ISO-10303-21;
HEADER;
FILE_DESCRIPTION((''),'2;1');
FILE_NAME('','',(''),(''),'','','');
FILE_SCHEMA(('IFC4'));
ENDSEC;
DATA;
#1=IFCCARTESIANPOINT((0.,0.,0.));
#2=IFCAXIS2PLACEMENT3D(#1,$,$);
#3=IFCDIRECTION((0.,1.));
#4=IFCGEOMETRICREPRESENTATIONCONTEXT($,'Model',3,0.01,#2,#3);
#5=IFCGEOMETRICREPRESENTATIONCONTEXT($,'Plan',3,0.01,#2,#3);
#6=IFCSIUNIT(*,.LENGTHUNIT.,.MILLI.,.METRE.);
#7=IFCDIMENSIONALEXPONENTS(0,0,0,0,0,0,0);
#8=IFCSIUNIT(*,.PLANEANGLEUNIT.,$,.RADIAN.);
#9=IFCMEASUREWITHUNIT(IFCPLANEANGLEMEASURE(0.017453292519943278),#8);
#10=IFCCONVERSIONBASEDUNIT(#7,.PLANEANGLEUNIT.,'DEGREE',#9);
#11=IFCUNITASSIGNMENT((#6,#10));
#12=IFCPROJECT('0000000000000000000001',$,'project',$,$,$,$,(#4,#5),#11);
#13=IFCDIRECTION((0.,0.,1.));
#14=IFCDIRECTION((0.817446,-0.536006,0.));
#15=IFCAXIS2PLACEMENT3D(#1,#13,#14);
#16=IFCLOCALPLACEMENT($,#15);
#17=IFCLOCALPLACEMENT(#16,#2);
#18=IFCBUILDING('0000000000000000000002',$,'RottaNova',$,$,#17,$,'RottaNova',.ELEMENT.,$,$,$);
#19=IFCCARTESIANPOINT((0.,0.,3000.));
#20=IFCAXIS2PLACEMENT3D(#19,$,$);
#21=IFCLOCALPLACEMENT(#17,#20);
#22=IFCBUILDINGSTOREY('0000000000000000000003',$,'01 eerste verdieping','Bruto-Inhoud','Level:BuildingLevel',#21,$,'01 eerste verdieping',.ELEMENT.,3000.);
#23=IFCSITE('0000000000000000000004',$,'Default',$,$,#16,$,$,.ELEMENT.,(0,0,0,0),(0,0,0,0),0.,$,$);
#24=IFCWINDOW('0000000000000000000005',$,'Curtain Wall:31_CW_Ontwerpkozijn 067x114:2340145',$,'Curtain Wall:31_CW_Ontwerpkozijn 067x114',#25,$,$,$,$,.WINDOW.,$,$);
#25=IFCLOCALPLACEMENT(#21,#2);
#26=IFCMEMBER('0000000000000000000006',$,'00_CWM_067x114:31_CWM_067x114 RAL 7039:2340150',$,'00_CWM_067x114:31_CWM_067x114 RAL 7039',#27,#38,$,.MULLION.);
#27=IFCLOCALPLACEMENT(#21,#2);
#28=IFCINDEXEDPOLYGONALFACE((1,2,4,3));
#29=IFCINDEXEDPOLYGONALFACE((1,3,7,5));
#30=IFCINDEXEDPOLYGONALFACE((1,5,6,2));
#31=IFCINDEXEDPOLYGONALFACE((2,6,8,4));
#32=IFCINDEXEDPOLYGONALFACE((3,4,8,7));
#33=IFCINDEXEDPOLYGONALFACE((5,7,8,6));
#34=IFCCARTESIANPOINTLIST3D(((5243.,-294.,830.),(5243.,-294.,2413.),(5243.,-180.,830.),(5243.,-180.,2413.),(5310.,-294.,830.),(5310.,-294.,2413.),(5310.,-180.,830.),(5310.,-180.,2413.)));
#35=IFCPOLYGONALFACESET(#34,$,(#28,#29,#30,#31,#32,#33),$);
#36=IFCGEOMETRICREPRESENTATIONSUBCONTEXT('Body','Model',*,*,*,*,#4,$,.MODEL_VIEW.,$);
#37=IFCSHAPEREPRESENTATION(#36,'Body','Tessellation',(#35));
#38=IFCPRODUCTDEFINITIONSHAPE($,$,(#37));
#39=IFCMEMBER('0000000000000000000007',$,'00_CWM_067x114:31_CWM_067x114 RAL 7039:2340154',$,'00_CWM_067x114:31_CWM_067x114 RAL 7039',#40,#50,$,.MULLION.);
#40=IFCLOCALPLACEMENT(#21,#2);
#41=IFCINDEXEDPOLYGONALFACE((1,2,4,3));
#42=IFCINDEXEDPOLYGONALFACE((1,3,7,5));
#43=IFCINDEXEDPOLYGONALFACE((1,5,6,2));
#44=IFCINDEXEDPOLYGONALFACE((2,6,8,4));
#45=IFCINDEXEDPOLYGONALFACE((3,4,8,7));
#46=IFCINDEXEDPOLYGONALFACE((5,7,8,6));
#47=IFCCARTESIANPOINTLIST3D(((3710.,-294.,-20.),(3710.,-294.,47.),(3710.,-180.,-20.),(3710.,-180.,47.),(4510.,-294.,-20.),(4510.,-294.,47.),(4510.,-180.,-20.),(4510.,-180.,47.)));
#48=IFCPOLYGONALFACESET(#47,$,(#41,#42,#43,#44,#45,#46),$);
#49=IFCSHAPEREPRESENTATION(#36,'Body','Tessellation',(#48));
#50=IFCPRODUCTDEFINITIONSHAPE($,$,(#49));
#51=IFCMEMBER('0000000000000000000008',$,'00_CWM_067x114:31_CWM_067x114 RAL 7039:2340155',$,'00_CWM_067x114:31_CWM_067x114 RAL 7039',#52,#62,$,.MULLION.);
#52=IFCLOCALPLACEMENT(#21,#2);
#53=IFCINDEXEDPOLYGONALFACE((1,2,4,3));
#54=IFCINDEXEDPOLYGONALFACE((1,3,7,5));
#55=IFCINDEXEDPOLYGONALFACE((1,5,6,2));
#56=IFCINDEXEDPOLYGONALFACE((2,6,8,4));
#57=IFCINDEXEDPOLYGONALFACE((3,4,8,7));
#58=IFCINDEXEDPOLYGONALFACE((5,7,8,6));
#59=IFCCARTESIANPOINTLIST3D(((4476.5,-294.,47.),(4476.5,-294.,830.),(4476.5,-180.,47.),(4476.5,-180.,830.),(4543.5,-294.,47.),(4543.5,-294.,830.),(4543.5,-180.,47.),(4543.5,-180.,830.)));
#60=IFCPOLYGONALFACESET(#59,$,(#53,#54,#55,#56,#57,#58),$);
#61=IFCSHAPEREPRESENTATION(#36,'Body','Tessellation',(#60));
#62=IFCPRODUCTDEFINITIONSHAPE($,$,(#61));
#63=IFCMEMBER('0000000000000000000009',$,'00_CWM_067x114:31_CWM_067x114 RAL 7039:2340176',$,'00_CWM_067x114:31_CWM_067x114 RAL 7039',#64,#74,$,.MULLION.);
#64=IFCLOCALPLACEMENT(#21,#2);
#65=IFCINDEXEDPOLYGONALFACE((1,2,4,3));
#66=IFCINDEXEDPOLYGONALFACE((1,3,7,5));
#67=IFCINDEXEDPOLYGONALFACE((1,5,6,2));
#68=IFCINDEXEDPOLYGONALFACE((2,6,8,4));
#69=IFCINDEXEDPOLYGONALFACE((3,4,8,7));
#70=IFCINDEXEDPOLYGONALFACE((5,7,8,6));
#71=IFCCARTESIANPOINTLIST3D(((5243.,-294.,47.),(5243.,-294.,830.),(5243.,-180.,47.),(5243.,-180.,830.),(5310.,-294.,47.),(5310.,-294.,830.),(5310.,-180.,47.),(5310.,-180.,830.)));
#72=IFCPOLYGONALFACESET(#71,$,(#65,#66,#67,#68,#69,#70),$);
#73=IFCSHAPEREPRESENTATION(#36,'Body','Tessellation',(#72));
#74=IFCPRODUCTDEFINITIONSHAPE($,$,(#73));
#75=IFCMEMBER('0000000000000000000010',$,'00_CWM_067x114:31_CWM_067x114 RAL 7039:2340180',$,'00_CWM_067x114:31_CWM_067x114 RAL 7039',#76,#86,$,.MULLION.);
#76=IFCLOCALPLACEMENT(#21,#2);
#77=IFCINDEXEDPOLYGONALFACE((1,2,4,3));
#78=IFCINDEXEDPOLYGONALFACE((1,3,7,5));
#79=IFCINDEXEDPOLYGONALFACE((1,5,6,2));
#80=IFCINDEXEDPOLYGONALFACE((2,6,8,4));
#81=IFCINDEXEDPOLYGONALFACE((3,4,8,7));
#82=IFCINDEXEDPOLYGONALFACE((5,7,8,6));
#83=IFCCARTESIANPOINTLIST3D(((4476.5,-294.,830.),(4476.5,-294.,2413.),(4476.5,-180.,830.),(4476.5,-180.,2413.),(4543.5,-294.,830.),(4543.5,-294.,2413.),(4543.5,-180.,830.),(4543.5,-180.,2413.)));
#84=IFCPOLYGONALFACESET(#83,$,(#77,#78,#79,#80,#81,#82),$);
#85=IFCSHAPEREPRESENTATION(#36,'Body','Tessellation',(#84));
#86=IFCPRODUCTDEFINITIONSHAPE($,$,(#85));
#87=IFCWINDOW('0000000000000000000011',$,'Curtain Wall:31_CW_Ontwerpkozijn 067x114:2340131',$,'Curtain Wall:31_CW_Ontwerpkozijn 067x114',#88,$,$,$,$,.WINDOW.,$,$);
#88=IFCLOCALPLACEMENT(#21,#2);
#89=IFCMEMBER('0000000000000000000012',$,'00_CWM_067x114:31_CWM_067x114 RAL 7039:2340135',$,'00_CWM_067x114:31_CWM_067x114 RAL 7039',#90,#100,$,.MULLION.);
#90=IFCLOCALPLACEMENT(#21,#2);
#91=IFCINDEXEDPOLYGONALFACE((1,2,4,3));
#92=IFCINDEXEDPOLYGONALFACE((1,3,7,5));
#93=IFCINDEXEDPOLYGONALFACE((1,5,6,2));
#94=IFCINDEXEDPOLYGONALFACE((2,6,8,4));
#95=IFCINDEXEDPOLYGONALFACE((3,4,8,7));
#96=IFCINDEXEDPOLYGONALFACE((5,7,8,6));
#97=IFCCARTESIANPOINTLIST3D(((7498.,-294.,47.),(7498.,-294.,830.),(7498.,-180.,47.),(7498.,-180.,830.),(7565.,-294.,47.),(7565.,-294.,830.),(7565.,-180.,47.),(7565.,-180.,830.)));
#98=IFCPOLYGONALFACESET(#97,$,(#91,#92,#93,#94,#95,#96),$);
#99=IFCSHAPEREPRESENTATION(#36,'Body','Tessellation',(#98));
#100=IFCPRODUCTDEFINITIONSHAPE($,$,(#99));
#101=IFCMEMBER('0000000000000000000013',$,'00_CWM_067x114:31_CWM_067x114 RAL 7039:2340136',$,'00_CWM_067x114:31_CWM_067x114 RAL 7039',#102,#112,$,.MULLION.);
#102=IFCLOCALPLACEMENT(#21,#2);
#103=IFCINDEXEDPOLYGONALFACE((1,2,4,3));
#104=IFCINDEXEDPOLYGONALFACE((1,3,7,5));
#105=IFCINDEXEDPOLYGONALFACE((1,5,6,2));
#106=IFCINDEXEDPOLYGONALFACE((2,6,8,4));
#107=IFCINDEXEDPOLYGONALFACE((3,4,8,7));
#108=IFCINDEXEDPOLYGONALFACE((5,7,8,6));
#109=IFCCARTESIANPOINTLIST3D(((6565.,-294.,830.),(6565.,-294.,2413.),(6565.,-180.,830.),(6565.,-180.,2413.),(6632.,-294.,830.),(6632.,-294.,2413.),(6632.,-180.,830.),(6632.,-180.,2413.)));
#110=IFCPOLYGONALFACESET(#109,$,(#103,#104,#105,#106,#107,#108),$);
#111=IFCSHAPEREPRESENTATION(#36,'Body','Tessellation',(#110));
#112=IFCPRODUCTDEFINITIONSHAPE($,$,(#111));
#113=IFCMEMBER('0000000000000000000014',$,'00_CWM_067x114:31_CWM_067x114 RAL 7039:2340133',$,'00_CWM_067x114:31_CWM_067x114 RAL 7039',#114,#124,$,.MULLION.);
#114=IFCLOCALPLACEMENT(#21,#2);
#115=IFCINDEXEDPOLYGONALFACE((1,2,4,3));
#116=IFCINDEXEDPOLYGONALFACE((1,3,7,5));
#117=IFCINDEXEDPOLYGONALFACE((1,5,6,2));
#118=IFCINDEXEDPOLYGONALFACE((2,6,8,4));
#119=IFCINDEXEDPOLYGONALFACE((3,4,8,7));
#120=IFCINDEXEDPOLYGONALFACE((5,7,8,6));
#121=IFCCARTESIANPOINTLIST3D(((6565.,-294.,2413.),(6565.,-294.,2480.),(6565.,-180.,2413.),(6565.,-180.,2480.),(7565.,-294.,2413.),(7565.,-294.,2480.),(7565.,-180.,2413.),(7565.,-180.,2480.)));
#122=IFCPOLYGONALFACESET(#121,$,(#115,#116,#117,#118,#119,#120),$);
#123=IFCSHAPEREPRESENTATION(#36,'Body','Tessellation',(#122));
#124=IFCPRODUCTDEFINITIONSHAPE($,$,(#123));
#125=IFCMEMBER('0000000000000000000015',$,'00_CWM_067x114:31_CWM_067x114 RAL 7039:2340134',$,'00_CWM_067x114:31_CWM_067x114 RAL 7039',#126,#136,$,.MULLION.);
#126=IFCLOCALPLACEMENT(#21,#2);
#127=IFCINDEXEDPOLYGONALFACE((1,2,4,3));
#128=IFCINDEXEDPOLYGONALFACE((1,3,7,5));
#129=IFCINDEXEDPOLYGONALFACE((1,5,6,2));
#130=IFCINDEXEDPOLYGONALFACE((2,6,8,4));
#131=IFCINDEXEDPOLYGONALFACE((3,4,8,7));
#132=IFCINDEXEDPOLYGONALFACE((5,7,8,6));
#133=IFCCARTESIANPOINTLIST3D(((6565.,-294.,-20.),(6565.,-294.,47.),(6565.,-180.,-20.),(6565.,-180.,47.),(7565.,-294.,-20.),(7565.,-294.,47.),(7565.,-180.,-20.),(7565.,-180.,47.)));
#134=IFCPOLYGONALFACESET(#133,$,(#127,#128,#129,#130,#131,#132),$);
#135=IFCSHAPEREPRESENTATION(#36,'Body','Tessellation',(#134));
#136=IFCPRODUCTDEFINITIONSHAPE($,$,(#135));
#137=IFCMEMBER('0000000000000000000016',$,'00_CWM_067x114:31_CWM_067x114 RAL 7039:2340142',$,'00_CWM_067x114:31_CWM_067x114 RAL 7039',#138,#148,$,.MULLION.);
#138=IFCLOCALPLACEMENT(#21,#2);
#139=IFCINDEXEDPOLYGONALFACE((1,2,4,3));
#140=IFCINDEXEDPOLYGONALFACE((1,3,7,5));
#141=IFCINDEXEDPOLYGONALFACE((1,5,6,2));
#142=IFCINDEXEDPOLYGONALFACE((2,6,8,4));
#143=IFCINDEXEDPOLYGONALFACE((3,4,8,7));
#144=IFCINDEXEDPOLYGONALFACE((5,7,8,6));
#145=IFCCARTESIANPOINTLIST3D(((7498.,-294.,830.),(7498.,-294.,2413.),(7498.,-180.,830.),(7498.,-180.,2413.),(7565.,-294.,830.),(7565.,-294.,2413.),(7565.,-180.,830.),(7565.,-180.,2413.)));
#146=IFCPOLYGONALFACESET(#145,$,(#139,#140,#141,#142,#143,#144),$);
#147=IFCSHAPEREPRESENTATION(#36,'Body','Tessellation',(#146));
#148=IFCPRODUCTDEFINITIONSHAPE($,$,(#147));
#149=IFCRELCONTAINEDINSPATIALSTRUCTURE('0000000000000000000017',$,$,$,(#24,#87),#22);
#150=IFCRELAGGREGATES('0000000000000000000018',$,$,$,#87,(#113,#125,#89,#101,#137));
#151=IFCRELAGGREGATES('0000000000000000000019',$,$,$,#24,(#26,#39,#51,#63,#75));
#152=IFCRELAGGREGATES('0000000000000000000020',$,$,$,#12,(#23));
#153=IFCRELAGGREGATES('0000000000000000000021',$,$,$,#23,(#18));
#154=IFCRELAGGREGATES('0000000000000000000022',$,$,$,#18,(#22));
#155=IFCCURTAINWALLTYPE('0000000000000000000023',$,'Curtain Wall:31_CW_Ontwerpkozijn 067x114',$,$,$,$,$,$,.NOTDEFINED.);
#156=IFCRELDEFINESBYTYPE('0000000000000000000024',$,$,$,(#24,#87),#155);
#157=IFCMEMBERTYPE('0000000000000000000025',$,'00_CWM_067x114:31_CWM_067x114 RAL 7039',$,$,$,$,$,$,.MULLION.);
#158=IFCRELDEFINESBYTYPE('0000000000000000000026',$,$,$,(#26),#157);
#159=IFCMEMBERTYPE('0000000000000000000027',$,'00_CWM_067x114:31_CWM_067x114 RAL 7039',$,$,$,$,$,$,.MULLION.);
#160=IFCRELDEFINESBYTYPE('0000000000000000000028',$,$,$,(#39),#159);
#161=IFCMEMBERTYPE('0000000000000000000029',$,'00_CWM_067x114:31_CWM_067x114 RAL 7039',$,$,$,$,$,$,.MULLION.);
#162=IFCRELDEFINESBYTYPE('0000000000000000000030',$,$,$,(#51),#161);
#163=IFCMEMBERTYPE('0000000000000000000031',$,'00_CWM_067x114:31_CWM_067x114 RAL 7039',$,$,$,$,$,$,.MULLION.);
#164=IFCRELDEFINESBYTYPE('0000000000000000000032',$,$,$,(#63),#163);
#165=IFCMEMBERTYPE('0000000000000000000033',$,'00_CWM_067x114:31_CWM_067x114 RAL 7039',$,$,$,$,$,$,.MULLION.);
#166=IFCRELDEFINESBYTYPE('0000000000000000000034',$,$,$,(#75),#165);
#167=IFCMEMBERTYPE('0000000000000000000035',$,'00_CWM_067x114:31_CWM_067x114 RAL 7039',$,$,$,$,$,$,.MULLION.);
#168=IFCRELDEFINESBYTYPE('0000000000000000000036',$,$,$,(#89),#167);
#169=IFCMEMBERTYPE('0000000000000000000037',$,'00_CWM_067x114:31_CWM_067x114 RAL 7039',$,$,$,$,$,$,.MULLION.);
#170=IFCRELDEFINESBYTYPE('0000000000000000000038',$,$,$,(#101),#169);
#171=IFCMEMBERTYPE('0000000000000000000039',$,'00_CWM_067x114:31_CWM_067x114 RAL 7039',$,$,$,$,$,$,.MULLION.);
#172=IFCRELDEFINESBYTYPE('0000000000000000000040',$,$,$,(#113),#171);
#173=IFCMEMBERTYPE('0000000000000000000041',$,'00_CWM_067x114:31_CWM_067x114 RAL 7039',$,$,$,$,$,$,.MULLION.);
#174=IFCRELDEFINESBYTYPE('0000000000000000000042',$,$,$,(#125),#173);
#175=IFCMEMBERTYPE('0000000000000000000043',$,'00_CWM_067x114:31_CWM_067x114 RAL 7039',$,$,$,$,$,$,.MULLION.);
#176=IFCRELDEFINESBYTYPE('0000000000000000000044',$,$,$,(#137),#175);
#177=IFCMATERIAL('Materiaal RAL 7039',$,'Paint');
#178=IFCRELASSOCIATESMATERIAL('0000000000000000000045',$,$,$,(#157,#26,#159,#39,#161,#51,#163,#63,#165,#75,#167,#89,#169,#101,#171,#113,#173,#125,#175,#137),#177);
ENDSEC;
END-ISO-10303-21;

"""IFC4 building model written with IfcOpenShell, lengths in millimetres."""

from ifc_helpers import new_model, entity, si_unit, converted_unit, direction, frame, origin, place, context, subcontext, project, spatial, indexed_curve, outline, extrude, source, transform, mapped, material, type_object, type_shapes, element, aggregate, save


model = new_model("IFC4")

# Units and contexts
model_context = context("Model", 3, precision=0.01, world=origin(), true_north=direction((0.0, 1.0)))
plan_context = context("Plan", 3, precision=0.01, world=origin(), true_north=direction((0.0, 1.0)))
body_context = subcontext(model_context, "Body", "Model", "MODEL_VIEW")
ifc_project = project(units=[si_unit("LENGTHUNIT", "METRE", prefix="MILLI"), converted_unit("PLANEANGLEUNIT", "DEGREE", entity("IfcPlaneAngleMeasure", 0.017453292519943278), si_unit("PLANEANGLEUNIT", "RADIAN"), dimensions=[0, 0, 0, 0, 0, 0, 0])], contexts=[model_context, plan_context])

# Site, building, storey
site_placement = place(None, frame((0.0, 0.0, 0.0), z_axis=(0.0, 0.0, 1.0), x_axis=(0.817446, -0.536006, 0.0)))
site = spatial("IfcSite", under=ifc_project, at=site_placement, Name="Default", CompositionType="ELEMENT", RefLatitude=(0, 0, 0, 0), RefLongitude=(0, 0, 0, 0), RefElevation=0.0)
building_placement = place(site_placement, origin())
building = spatial("IfcBuilding", under=site, at=building_placement, Name="RottaNova", LongName="RottaNova", CompositionType="ELEMENT")
storey_placement = place(building_placement, frame((0.0, 0.0, 3000.0)))
storey = spatial("IfcBuildingStorey", under=building, at=storey_placement, Name="01 eerste verdieping", Description="Bruto-Inhoud", ObjectType="Level:BuildingLevel", LongName="01 eerste verdieping", CompositionType="ELEMENT", Elevation=3000.0)

# Windows, members
curtain_wall_type = type_object("IfcCurtainWallType", Name="Curtain Wall:31_CW_Ontwerpkozijn 067x114", PredefinedType="NOTDEFINED")
window_1_placement = place(storey_placement, frame((0.0, 0.0, -3000.0)))
window_1 = element("IfcWindow", 1, at=window_1_placement, inside=storey, type_object=curtain_wall_type, Name="Curtain Wall:31_CW_Ontwerpkozijn 067x114:2340145", ObjectType="Curtain Wall:31_CW_Ontwerpkozijn 067x114", PredefinedType="WINDOW")
ifc_material_1 = material(Name="Materiaal RAL 7039", Category="Paint")
member_type_1 = type_object("IfcMemberType", Name="00_CWM_067x114:31_CWM_067x114 RAL 7039", PredefinedType="MULLION", material=ifc_material_1)
shared_shape_1 = source(origin(), body_context, "Body", "SweptSolid", [
    extrude(outline(indexed_curve([(-33.5, -57.0), (33.5, -57.0), (33.5, 57.0), (-33.5, 57.0), (-33.5, -57.0)], self_intersect=False)), frame((-33.5, -57.0, -1583.0), z_axis=(0.0, 0.0, 1.0), x_axis=(-1.0, 0.0, 0.0)), (0.0, 0.0, 1.0), 1583.0),
])
type_shapes(member_type_1, [shared_shape_1])
member_1_placement = place(window_1_placement, frame((5310.0, -180.0, 5413.0)))
member_1 = element("IfcMember", 2, at=member_1_placement, type_object=member_type_1, material=ifc_material_1, Name="00_CWM_067x114:31_CWM_067x114 RAL 7039:2340150", ObjectType="00_CWM_067x114:31_CWM_067x114 RAL 7039", PredefinedType="MULLION", context=body_context, shape_type="MappedRepresentation", body=[
    mapped(shared_shape_1, transform((0.0, 0.0, 0.0), scale=1.0)),
])
member_type_2 = type_object("IfcMemberType", Name="00_CWM_067x114:31_CWM_067x114 RAL 7039", PredefinedType="MULLION", material=ifc_material_1)
shared_shape_2 = source(origin(), body_context, "Body", "SweptSolid", [
    extrude(outline(indexed_curve([(-33.5, -57.0), (33.5, -57.0), (33.5, 57.0), (-33.5, 57.0), (-33.5, -57.0)], self_intersect=False)), frame((-33.5, -57.0, -800.0), z_axis=(0.0, 0.0, 1.0), x_axis=(-1.0, 0.0, 0.0)), (0.0, 0.0, 1.0), 800.0),
])
type_shapes(member_type_2, [shared_shape_2])
member_2_placement = place(window_1_placement, frame((4510.0, -180.0, 2980.0), z_axis=(1.0, 0.0, 0.0), x_axis=(0.0, 0.0, -1.0)))
member_2 = element("IfcMember", 3, at=member_2_placement, type_object=member_type_2, material=ifc_material_1, Name="00_CWM_067x114:31_CWM_067x114 RAL 7039:2340154", ObjectType="00_CWM_067x114:31_CWM_067x114 RAL 7039", PredefinedType="MULLION", context=body_context, shape_type="MappedRepresentation", body=[
    mapped(shared_shape_2, transform((0.0, 0.0, 0.0), scale=1.0)),
])
member_type_3 = type_object("IfcMemberType", Name="00_CWM_067x114:31_CWM_067x114 RAL 7039", PredefinedType="MULLION", material=ifc_material_1)
shared_shape_3 = source(origin(), body_context, "Body", "SweptSolid", [
    extrude(outline(indexed_curve([(-33.5, -57.0), (33.5, -57.0), (33.5, 57.0), (-33.5, 57.0), (-33.5, -57.0)], self_intersect=False)), frame((0.0, -57.0, -783.0), z_axis=(0.0, 0.0, 1.0), x_axis=(-1.0, 0.0, 0.0)), (0.0, 0.0, 1.0), 783.0),
])
type_shapes(member_type_3, [shared_shape_3])
member_3_placement = place(window_1_placement, frame((4510.0, -180.0, 3047.0), z_axis=(0.0, 0.0, -1.0), x_axis=(-1.0, 0.0, 0.0)))
member_3 = element("IfcMember", 4, at=member_3_placement, type_object=member_type_3, material=ifc_material_1, Name="00_CWM_067x114:31_CWM_067x114 RAL 7039:2340155", ObjectType="00_CWM_067x114:31_CWM_067x114 RAL 7039", PredefinedType="MULLION", context=body_context, shape_type="MappedRepresentation", body=[
    mapped(shared_shape_3, transform((0.0, 0.0, 0.0), scale=1.0)),
])
member_type_4 = type_object("IfcMemberType", Name="00_CWM_067x114:31_CWM_067x114 RAL 7039", PredefinedType="MULLION", material=ifc_material_1)
shared_shape_4 = source(origin(), body_context, "Body", "SweptSolid", [
    extrude(outline(indexed_curve([(-33.5, -57.0), (33.5, -57.0), (33.5, 57.0), (-33.5, 57.0), (-33.5, -57.0)], self_intersect=False)), frame((-33.5, -57.0, -783.0), z_axis=(0.0, 0.0, 1.0), x_axis=(-1.0, 0.0, 0.0)), (0.0, 0.0, 1.0), 783.0),
])
type_shapes(member_type_4, [shared_shape_4])
member_4_placement = place(window_1_placement, frame((5310.0, -180.0, 3830.0)))
member_4 = element("IfcMember", 5, at=member_4_placement, type_object=member_type_4, material=ifc_material_1, Name="00_CWM_067x114:31_CWM_067x114 RAL 7039:2340176", ObjectType="00_CWM_067x114:31_CWM_067x114 RAL 7039", PredefinedType="MULLION", context=body_context, shape_type="MappedRepresentation", body=[
    mapped(shared_shape_4, transform((0.0, 0.0, 0.0), scale=1.0)),
])
member_type_5 = type_object("IfcMemberType", Name="00_CWM_067x114:31_CWM_067x114 RAL 7039", PredefinedType="MULLION", material=ifc_material_1)
shared_shape_5 = source(origin(), body_context, "Body", "SweptSolid", [
    extrude(outline(indexed_curve([(-33.5, -57.0), (33.5, -57.0), (33.5, 57.0), (-33.5, 57.0), (-33.5, -57.0)], self_intersect=False)), frame((0.0, -57.0, -1583.0), z_axis=(0.0, 0.0, 1.0), x_axis=(-1.0, 0.0, 0.0)), (0.0, 0.0, 1.0), 1583.0),
])
type_shapes(member_type_5, [shared_shape_5])
member_5_placement = place(window_1_placement, frame((4510.0, -180.0, 3830.0), z_axis=(0.0, 0.0, -1.0), x_axis=(-1.0, 0.0, 0.0)))
member_5 = element("IfcMember", 6, at=member_5_placement, type_object=member_type_5, material=ifc_material_1, Name="00_CWM_067x114:31_CWM_067x114 RAL 7039:2340180", ObjectType="00_CWM_067x114:31_CWM_067x114 RAL 7039", PredefinedType="MULLION", context=body_context, shape_type="MappedRepresentation", body=[
    mapped(shared_shape_5, transform((0.0, 0.0, 0.0), scale=1.0)),
])
window_2_placement = place(storey_placement, frame((0.0, 0.0, -3000.0)))
window_2 = element("IfcWindow", 7, at=window_2_placement, inside=storey, type_object=curtain_wall_type, Name="Curtain Wall:31_CW_Ontwerpkozijn 067x114:2340131", ObjectType="Curtain Wall:31_CW_Ontwerpkozijn 067x114", PredefinedType="WINDOW")
member_type_6 = type_object("IfcMemberType", Name="00_CWM_067x114:31_CWM_067x114 RAL 7039", PredefinedType="MULLION", material=ifc_material_1)
shared_shape_6 = source(origin(), body_context, "Body", "SweptSolid", [
    extrude(outline(indexed_curve([(-33.5, -57.0), (33.5, -57.0), (33.5, 57.0), (-33.5, 57.0), (-33.5, -57.0)], self_intersect=False)), frame((-33.5, 57.0, -783.0), z_axis=(0.0, 0.0, 1.0), x_axis=(-1.0, 0.0, 0.0)), (0.0, 0.0, 1.0), 783.0),
])
type_shapes(member_type_6, [shared_shape_6])
member_6_placement = place(window_2_placement, frame((7565.0, -180.0, 3047.0), z_axis=(0.0, 0.0, -1.0), x_axis=(1.0, 0.0, 0.0)))
member_6 = element("IfcMember", 8, at=member_6_placement, type_object=member_type_6, material=ifc_material_1, Name="00_CWM_067x114:31_CWM_067x114 RAL 7039:2340135", ObjectType="00_CWM_067x114:31_CWM_067x114 RAL 7039", PredefinedType="MULLION", context=body_context, shape_type="MappedRepresentation", body=[
    mapped(shared_shape_6, transform((0.0, 0.0, 0.0), scale=1.0)),
])
member_type_7 = type_object("IfcMemberType", Name="00_CWM_067x114:31_CWM_067x114 RAL 7039", PredefinedType="MULLION", material=ifc_material_1)
shared_shape_7 = source(origin(), body_context, "Body", "SweptSolid", [
    extrude(outline(indexed_curve([(-33.5, -57.0), (33.5, -57.0), (33.5, 57.0), (-33.5, 57.0), (-33.5, -57.0)], self_intersect=False)), frame((-33.5, 57.0, -1583.0), z_axis=(0.0, 0.0, 1.0), x_axis=(-1.0, 0.0, 0.0)), (0.0, 0.0, 1.0), 1583.0),
])
type_shapes(member_type_7, [shared_shape_7])
member_7_placement = place(window_2_placement, frame((6565.0, -180.0, 5413.0), z_axis=(0.0, 0.0, 1.0), x_axis=(-1.0, 0.0, 0.0)))
member_7 = element("IfcMember", 9, at=member_7_placement, type_object=member_type_7, material=ifc_material_1, Name="00_CWM_067x114:31_CWM_067x114 RAL 7039:2340136", ObjectType="00_CWM_067x114:31_CWM_067x114 RAL 7039", PredefinedType="MULLION", context=body_context, shape_type="MappedRepresentation", body=[
    mapped(shared_shape_7, transform((0.0, 0.0, 0.0), scale=1.0)),
])
member_type_8 = type_object("IfcMemberType", Name="00_CWM_067x114:31_CWM_067x114 RAL 7039", PredefinedType="MULLION", material=ifc_material_1)
shared_shape_8 = source(origin(), body_context, "Body", "SweptSolid", [
    extrude(outline(indexed_curve([(-33.5, -57.0), (33.5, -57.0), (33.5, 57.0), (-33.5, 57.0), (-33.5, -57.0)], self_intersect=False)), frame((-33.5, 57.0, -1000.0), z_axis=(0.0, 0.0, 1.0), x_axis=(-1.0, 0.0, 0.0)), (0.0, 0.0, 1.0), 1000.0),
])
type_shapes(member_type_8, [shared_shape_8])
member_8_placement = place(window_2_placement, frame((7565.0, -180.0, 5480.0), z_axis=(1.0, 0.0, 0.0), x_axis=(0.0, 0.0, 1.0)))
member_8 = element("IfcMember", 10, at=member_8_placement, type_object=member_type_8, material=ifc_material_1, Name="00_CWM_067x114:31_CWM_067x114 RAL 7039:2340133", ObjectType="00_CWM_067x114:31_CWM_067x114 RAL 7039", PredefinedType="MULLION", context=body_context, shape_type="MappedRepresentation", body=[
    mapped(shared_shape_8, transform((0.0, 0.0, 0.0), scale=1.0)),
])
member_type_9 = type_object("IfcMemberType", Name="00_CWM_067x114:31_CWM_067x114 RAL 7039", PredefinedType="MULLION", material=ifc_material_1)
shared_shape_9 = source(origin(), body_context, "Body", "SweptSolid", [
    extrude(outline(indexed_curve([(-33.5, -57.0), (33.5, -57.0), (33.5, 57.0), (-33.5, 57.0), (-33.5, -57.0)], self_intersect=False)), frame((-33.5, 57.0, -1000.0), z_axis=(0.0, 0.0, 1.0), x_axis=(-1.0, 0.0, 0.0)), (0.0, 0.0, 1.0), 1000.0),
])
type_shapes(member_type_9, [shared_shape_9])
member_9_placement = place(window_2_placement, frame((6565.0, -180.0, 2980.0), z_axis=(-1.0, 0.0, 0.0), x_axis=(0.0, 0.0, -1.0)))
member_9 = element("IfcMember", 11, at=member_9_placement, type_object=member_type_9, material=ifc_material_1, Name="00_CWM_067x114:31_CWM_067x114 RAL 7039:2340134", ObjectType="00_CWM_067x114:31_CWM_067x114 RAL 7039", PredefinedType="MULLION", context=body_context, shape_type="MappedRepresentation", body=[
    mapped(shared_shape_9, transform((0.0, 0.0, 0.0), scale=1.0)),
])
member_type_10 = type_object("IfcMemberType", Name="00_CWM_067x114:31_CWM_067x114 RAL 7039", PredefinedType="MULLION", material=ifc_material_1)
shared_shape_10 = source(origin(), body_context, "Body", "SweptSolid", [
    extrude(outline(indexed_curve([(-33.5, -57.0), (33.5, -57.0), (33.5, 57.0), (-33.5, 57.0), (-33.5, -57.0)], self_intersect=False)), frame((-33.5, 57.0, -1583.0), z_axis=(0.0, 0.0, 1.0), x_axis=(-1.0, 0.0, 0.0)), (0.0, 0.0, 1.0), 1583.0),
])
type_shapes(member_type_10, [shared_shape_10])
member_10_placement = place(window_2_placement, frame((7565.0, -180.0, 3830.0), z_axis=(0.0, 0.0, -1.0), x_axis=(1.0, 0.0, 0.0)))
member_10 = element("IfcMember", 12, at=member_10_placement, type_object=member_type_10, material=ifc_material_1, Name="00_CWM_067x114:31_CWM_067x114 RAL 7039:2340142", ObjectType="00_CWM_067x114:31_CWM_067x114 RAL 7039", PredefinedType="MULLION", context=body_context, shape_type="MappedRepresentation", body=[
    mapped(shared_shape_10, transform((0.0, 0.0, 0.0), scale=1.0)),
])

aggregate(window_2, [member_8, member_9, member_6, member_7, member_10])
aggregate(window_1, [member_1, member_2, member_3, member_4, member_5])

save(model, "model.ifc")
